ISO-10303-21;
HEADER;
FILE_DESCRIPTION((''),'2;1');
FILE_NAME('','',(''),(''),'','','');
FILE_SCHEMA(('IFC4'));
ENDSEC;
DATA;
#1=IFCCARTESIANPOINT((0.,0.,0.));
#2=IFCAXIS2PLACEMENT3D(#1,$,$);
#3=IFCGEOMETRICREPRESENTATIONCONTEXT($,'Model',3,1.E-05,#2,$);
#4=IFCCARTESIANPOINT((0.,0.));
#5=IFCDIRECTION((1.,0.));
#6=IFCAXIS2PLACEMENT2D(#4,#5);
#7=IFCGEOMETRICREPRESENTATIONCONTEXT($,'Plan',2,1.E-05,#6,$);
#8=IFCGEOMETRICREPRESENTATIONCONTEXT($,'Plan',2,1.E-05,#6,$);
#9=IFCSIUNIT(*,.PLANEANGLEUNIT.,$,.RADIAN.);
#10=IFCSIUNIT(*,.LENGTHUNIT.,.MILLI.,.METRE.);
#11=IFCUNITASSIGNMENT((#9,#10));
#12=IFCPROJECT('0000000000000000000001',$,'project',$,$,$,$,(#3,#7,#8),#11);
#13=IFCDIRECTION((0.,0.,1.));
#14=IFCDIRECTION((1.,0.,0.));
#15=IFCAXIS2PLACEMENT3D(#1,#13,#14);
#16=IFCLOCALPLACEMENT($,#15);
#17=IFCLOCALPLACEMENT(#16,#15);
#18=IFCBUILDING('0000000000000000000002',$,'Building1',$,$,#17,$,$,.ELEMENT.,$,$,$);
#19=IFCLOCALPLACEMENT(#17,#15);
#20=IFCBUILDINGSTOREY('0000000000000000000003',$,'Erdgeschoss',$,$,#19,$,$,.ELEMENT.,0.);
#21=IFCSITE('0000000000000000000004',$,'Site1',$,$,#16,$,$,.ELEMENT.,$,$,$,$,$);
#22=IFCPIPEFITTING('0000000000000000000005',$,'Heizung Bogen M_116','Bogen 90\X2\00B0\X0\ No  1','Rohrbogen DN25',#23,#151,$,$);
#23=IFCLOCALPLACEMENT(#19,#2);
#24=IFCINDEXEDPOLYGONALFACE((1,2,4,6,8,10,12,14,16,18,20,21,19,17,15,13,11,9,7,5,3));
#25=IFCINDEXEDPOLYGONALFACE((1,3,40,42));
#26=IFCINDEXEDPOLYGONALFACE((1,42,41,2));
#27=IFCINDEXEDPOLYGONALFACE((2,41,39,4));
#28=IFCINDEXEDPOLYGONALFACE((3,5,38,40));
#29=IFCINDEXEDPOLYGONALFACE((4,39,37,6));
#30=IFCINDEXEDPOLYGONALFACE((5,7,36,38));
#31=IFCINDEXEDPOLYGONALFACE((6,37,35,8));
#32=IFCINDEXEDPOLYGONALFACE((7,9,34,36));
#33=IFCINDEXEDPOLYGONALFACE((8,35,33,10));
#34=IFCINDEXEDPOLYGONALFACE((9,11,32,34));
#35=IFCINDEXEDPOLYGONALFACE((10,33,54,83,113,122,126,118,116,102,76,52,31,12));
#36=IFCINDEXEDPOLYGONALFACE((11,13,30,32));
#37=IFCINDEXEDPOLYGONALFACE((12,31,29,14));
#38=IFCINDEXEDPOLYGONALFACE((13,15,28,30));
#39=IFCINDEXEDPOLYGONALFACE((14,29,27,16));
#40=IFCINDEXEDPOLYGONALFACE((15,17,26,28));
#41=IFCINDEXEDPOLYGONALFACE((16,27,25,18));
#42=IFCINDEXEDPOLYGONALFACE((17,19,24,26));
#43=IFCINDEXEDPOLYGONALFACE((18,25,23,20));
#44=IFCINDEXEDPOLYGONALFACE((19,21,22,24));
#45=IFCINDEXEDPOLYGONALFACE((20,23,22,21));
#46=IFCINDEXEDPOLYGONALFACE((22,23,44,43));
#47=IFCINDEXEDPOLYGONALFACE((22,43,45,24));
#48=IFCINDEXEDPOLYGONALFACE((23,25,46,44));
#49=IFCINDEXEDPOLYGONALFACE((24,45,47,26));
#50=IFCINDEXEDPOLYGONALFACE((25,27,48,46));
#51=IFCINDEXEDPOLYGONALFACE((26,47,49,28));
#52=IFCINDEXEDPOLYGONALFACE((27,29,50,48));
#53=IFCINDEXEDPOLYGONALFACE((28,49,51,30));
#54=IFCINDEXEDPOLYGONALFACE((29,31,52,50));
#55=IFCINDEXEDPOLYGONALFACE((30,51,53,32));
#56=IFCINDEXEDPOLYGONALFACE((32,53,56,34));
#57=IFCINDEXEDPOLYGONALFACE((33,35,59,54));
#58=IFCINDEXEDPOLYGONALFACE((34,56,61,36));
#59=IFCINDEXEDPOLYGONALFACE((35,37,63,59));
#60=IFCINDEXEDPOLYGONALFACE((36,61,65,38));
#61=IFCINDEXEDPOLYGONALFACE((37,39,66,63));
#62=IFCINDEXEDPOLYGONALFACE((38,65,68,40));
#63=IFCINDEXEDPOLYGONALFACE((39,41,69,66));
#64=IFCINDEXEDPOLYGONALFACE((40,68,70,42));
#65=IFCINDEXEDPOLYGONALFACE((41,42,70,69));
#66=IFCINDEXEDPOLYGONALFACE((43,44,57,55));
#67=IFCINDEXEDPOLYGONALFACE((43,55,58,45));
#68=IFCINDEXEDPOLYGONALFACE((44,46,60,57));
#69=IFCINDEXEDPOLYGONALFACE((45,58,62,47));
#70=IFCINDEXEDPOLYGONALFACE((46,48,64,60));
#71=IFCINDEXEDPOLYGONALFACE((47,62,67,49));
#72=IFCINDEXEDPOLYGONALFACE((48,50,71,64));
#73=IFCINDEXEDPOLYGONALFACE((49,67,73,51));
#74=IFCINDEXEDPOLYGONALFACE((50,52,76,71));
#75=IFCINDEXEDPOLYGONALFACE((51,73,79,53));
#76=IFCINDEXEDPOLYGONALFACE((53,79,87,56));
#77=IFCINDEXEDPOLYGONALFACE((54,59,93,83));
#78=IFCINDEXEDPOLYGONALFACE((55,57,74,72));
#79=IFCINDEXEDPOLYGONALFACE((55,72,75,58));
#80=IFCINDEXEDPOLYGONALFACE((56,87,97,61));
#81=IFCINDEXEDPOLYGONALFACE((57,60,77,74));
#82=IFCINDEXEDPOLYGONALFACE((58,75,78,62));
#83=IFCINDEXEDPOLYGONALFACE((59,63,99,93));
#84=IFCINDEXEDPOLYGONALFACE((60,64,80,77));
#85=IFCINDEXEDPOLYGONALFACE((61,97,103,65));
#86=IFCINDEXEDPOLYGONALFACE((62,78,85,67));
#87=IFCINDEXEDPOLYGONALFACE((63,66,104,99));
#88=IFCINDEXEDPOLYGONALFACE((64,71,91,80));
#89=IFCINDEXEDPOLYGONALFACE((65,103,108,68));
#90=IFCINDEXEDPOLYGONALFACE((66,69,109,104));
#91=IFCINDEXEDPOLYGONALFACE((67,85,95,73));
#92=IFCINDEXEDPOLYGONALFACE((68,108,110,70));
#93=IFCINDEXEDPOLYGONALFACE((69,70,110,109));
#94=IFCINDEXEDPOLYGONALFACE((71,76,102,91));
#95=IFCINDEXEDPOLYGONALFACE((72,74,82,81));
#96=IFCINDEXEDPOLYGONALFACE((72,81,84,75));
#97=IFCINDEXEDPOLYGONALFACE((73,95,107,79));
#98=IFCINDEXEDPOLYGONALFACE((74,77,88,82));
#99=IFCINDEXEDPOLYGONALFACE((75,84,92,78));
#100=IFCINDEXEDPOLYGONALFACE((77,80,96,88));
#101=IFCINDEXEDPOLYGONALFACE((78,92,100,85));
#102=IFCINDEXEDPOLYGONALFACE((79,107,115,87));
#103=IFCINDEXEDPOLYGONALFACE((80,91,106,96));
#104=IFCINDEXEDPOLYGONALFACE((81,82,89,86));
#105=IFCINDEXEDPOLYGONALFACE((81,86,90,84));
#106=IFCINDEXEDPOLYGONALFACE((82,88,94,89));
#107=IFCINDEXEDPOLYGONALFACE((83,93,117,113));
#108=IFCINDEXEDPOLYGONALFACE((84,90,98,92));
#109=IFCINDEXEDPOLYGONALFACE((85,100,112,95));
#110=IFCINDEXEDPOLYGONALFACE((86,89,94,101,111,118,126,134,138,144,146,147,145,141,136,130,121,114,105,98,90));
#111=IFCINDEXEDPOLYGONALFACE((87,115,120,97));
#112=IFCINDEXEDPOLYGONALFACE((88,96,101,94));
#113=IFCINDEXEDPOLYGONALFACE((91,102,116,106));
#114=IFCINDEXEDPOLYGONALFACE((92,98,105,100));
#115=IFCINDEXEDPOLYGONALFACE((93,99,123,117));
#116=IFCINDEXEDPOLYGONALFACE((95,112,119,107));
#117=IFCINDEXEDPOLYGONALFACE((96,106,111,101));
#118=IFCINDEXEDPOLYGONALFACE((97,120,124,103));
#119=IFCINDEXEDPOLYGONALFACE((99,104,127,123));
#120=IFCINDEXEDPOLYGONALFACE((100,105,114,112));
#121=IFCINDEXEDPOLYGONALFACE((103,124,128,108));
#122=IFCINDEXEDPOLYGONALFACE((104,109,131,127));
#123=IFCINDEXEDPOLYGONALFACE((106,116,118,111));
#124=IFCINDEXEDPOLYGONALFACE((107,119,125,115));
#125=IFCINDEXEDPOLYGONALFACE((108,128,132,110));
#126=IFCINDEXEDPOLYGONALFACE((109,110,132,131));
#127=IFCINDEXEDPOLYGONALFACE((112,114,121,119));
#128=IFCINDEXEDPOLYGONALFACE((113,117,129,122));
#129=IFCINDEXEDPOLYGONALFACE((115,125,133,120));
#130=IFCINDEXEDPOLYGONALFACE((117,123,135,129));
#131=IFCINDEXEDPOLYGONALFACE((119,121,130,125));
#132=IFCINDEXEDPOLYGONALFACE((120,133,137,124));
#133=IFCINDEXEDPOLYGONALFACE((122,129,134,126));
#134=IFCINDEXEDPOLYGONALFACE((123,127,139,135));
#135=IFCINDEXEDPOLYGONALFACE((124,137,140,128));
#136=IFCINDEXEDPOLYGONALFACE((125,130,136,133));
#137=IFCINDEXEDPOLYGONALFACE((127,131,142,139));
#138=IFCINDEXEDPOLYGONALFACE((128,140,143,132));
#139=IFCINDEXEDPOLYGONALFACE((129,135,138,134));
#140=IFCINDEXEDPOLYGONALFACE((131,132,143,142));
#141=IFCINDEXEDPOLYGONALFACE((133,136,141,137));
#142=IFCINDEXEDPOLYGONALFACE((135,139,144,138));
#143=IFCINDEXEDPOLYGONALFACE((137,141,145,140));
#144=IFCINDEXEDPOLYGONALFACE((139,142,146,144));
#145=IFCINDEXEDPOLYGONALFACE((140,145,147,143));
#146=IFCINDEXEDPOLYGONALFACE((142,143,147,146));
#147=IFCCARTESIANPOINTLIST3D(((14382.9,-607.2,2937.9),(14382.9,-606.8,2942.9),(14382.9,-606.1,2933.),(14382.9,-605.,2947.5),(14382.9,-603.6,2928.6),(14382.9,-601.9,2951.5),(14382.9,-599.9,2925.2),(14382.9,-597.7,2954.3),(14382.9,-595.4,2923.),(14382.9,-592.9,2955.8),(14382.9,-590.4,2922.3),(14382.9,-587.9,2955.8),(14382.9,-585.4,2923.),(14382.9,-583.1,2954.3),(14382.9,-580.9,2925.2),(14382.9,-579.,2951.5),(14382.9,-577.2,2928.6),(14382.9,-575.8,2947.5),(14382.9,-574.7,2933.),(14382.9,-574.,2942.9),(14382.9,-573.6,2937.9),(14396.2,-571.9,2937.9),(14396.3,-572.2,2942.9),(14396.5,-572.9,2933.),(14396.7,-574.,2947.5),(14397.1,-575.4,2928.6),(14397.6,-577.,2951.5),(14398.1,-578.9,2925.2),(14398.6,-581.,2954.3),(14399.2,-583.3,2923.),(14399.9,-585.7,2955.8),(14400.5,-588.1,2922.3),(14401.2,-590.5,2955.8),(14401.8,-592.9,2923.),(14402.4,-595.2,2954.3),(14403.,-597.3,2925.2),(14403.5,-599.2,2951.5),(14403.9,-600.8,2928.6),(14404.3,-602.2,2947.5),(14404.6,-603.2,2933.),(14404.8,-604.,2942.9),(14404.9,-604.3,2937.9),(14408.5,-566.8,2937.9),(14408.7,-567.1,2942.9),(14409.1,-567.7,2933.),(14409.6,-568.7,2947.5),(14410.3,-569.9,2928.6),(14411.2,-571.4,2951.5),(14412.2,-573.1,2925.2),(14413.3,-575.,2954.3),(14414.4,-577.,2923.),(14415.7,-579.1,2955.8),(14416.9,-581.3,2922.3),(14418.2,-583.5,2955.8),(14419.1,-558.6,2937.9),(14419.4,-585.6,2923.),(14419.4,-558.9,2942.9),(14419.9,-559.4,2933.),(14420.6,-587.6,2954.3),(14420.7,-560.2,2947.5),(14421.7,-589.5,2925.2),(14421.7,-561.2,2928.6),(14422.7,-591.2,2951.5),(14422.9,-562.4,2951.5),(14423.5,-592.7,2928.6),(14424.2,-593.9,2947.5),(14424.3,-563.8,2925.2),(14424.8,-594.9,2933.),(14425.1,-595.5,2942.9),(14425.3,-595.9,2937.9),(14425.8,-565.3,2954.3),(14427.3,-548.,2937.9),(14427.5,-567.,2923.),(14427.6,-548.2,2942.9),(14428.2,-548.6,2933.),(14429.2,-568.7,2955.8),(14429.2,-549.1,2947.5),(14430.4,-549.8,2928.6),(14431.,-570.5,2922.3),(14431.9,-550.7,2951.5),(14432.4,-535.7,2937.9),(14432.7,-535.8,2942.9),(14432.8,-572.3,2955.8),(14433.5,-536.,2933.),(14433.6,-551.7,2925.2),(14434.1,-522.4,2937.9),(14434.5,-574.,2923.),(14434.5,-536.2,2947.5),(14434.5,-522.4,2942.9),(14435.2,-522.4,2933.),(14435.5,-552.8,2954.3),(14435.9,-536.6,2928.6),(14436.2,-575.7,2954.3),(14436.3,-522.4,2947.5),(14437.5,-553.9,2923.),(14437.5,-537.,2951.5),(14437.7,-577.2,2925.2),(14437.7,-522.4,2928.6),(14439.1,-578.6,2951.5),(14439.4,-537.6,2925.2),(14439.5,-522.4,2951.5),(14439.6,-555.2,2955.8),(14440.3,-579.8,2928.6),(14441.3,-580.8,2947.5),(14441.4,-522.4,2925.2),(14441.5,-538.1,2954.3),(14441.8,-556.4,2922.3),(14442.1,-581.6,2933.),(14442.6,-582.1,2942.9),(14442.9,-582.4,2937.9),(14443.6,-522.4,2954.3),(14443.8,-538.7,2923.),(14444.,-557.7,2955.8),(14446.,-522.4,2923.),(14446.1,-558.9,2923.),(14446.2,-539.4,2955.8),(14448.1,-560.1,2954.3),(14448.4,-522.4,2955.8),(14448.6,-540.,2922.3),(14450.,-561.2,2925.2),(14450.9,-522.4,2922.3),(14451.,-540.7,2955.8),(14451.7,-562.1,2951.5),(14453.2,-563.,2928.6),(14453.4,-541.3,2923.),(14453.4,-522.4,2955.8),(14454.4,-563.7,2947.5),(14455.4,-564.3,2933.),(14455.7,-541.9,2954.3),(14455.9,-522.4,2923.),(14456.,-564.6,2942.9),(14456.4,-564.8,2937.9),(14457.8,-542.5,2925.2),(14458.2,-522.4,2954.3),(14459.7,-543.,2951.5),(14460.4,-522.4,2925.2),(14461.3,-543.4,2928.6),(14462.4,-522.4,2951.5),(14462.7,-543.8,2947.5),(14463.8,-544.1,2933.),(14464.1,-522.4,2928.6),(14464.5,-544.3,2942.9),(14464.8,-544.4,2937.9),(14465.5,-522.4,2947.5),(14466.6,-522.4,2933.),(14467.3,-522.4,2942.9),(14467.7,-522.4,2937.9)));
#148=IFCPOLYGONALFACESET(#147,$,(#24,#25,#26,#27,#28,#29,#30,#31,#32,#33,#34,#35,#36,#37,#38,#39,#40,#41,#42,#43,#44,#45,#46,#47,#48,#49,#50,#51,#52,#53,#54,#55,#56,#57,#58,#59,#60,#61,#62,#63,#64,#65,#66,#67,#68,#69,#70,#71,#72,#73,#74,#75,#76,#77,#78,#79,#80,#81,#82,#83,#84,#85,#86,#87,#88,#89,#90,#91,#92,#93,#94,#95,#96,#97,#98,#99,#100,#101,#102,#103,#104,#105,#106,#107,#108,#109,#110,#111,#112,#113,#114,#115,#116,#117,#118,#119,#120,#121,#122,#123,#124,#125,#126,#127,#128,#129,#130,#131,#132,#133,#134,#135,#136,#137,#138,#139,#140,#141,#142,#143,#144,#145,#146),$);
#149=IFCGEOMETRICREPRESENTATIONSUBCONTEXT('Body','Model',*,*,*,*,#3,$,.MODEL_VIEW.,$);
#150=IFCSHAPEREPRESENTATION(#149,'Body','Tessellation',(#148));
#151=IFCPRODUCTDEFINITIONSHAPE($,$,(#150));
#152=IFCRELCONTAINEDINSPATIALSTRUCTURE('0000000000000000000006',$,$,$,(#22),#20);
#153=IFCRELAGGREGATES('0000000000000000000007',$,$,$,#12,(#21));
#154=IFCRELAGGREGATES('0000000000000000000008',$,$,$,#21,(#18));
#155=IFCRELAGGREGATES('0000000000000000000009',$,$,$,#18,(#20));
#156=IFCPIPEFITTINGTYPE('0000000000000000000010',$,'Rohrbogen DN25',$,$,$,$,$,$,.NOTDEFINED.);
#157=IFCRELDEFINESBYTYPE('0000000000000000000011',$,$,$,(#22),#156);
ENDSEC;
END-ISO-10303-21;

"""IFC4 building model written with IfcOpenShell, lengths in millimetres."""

from ifc_helpers import new_model, entity, si_unit, frame, origin, origin_with_axes, origin_2d_with_axis, place, context, subcontext, project, spatial, source, transform, mapped, type_object, element, save


model = new_model("IFC4")

# Units and contexts
model_context = context("Model", 3, precision=1e-05, world=origin())
plan_context_1 = context("Plan", 2, precision=1e-05, world=origin_2d_with_axis())
plan_context_2 = context("Plan", 2, precision=1e-05, world=origin_2d_with_axis())
body_context = subcontext(model_context, "Body", "Model", "MODEL_VIEW")
ifc_project = project(units=[si_unit("PLANEANGLEUNIT", "RADIAN"), si_unit("LENGTHUNIT", "METRE", prefix="MILLI")], contexts=[model_context, plan_context_1, plan_context_2])

# Site, building, storey
site_placement = place(None, origin_with_axes())
site = spatial("IfcSite", under=ifc_project, at=site_placement, Name="Site1", CompositionType="ELEMENT")
building_placement = place(site_placement, origin_with_axes())
building = spatial("IfcBuilding", under=site, at=building_placement, Name="Building1", CompositionType="ELEMENT")
storey_placement = place(building_placement, origin_with_axes())
storey = spatial("IfcBuildingStorey", under=building, at=storey_placement, Name="Erdgeschoss", CompositionType="ELEMENT", Elevation=0.0)

# Pipe fitting
pipe_fitting_type = type_object("IfcPipeFittingType", Name="Rohrbogen DN25", PredefinedType="NOTDEFINED")
shared_shape_1 = source(origin_with_axes(), body_context, "Body", "SolidModel", [
    entity("IfcRevolvedAreaSolid", entity("IfcCircleProfileDef", "AREA", None, entity("IfcAxis2Placement2D", entity("IfcCartesianPoint", [0.0, 0.0]), entity("IfcDirection", [1.0, 0.0])), 16.9), entity("IfcAxis2Placement3D", entity("IfcCartesianPoint", [-42.4, 25.6, 0.0]), entity("IfcDirection", [1.0, 0.0, 0.0]), entity("IfcDirection", [0.0, 0.0, 1.0])), entity("IfcAxis1Placement", entity("IfcCartesianPoint", [0.0, 68.0, 0.0]), entity("IfcDirection", [-1.0, 0.0, 0.0])), 1.570796),
])
pipe_fitting_1_placement = place(storey_placement, frame((14425.3, -564.8, 2939.1), z_axis=(0.0, 0.0, 1.0), x_axis=(1.0, 0.0, 0.0)))
element("IfcPipeFitting", 1, at=pipe_fitting_1_placement, inside=storey, type_object=pipe_fitting_type, Name="Heizung Bogen M_116", Description="Bogen 90° No  1", ObjectType="Rohrbogen DN25", context=body_context, shape_type="MappedRepresentation", body=[
    mapped(shared_shape_1, transform((0.0, 0.0, 0.0), x_axis=(1.0, 0.0, 0.0), y_axis=(0.0, -1.0, 0.0), z_axis=(0.0, 0.0, -1.0), scale=1.0)),
])

save(model, "model.ifc")
